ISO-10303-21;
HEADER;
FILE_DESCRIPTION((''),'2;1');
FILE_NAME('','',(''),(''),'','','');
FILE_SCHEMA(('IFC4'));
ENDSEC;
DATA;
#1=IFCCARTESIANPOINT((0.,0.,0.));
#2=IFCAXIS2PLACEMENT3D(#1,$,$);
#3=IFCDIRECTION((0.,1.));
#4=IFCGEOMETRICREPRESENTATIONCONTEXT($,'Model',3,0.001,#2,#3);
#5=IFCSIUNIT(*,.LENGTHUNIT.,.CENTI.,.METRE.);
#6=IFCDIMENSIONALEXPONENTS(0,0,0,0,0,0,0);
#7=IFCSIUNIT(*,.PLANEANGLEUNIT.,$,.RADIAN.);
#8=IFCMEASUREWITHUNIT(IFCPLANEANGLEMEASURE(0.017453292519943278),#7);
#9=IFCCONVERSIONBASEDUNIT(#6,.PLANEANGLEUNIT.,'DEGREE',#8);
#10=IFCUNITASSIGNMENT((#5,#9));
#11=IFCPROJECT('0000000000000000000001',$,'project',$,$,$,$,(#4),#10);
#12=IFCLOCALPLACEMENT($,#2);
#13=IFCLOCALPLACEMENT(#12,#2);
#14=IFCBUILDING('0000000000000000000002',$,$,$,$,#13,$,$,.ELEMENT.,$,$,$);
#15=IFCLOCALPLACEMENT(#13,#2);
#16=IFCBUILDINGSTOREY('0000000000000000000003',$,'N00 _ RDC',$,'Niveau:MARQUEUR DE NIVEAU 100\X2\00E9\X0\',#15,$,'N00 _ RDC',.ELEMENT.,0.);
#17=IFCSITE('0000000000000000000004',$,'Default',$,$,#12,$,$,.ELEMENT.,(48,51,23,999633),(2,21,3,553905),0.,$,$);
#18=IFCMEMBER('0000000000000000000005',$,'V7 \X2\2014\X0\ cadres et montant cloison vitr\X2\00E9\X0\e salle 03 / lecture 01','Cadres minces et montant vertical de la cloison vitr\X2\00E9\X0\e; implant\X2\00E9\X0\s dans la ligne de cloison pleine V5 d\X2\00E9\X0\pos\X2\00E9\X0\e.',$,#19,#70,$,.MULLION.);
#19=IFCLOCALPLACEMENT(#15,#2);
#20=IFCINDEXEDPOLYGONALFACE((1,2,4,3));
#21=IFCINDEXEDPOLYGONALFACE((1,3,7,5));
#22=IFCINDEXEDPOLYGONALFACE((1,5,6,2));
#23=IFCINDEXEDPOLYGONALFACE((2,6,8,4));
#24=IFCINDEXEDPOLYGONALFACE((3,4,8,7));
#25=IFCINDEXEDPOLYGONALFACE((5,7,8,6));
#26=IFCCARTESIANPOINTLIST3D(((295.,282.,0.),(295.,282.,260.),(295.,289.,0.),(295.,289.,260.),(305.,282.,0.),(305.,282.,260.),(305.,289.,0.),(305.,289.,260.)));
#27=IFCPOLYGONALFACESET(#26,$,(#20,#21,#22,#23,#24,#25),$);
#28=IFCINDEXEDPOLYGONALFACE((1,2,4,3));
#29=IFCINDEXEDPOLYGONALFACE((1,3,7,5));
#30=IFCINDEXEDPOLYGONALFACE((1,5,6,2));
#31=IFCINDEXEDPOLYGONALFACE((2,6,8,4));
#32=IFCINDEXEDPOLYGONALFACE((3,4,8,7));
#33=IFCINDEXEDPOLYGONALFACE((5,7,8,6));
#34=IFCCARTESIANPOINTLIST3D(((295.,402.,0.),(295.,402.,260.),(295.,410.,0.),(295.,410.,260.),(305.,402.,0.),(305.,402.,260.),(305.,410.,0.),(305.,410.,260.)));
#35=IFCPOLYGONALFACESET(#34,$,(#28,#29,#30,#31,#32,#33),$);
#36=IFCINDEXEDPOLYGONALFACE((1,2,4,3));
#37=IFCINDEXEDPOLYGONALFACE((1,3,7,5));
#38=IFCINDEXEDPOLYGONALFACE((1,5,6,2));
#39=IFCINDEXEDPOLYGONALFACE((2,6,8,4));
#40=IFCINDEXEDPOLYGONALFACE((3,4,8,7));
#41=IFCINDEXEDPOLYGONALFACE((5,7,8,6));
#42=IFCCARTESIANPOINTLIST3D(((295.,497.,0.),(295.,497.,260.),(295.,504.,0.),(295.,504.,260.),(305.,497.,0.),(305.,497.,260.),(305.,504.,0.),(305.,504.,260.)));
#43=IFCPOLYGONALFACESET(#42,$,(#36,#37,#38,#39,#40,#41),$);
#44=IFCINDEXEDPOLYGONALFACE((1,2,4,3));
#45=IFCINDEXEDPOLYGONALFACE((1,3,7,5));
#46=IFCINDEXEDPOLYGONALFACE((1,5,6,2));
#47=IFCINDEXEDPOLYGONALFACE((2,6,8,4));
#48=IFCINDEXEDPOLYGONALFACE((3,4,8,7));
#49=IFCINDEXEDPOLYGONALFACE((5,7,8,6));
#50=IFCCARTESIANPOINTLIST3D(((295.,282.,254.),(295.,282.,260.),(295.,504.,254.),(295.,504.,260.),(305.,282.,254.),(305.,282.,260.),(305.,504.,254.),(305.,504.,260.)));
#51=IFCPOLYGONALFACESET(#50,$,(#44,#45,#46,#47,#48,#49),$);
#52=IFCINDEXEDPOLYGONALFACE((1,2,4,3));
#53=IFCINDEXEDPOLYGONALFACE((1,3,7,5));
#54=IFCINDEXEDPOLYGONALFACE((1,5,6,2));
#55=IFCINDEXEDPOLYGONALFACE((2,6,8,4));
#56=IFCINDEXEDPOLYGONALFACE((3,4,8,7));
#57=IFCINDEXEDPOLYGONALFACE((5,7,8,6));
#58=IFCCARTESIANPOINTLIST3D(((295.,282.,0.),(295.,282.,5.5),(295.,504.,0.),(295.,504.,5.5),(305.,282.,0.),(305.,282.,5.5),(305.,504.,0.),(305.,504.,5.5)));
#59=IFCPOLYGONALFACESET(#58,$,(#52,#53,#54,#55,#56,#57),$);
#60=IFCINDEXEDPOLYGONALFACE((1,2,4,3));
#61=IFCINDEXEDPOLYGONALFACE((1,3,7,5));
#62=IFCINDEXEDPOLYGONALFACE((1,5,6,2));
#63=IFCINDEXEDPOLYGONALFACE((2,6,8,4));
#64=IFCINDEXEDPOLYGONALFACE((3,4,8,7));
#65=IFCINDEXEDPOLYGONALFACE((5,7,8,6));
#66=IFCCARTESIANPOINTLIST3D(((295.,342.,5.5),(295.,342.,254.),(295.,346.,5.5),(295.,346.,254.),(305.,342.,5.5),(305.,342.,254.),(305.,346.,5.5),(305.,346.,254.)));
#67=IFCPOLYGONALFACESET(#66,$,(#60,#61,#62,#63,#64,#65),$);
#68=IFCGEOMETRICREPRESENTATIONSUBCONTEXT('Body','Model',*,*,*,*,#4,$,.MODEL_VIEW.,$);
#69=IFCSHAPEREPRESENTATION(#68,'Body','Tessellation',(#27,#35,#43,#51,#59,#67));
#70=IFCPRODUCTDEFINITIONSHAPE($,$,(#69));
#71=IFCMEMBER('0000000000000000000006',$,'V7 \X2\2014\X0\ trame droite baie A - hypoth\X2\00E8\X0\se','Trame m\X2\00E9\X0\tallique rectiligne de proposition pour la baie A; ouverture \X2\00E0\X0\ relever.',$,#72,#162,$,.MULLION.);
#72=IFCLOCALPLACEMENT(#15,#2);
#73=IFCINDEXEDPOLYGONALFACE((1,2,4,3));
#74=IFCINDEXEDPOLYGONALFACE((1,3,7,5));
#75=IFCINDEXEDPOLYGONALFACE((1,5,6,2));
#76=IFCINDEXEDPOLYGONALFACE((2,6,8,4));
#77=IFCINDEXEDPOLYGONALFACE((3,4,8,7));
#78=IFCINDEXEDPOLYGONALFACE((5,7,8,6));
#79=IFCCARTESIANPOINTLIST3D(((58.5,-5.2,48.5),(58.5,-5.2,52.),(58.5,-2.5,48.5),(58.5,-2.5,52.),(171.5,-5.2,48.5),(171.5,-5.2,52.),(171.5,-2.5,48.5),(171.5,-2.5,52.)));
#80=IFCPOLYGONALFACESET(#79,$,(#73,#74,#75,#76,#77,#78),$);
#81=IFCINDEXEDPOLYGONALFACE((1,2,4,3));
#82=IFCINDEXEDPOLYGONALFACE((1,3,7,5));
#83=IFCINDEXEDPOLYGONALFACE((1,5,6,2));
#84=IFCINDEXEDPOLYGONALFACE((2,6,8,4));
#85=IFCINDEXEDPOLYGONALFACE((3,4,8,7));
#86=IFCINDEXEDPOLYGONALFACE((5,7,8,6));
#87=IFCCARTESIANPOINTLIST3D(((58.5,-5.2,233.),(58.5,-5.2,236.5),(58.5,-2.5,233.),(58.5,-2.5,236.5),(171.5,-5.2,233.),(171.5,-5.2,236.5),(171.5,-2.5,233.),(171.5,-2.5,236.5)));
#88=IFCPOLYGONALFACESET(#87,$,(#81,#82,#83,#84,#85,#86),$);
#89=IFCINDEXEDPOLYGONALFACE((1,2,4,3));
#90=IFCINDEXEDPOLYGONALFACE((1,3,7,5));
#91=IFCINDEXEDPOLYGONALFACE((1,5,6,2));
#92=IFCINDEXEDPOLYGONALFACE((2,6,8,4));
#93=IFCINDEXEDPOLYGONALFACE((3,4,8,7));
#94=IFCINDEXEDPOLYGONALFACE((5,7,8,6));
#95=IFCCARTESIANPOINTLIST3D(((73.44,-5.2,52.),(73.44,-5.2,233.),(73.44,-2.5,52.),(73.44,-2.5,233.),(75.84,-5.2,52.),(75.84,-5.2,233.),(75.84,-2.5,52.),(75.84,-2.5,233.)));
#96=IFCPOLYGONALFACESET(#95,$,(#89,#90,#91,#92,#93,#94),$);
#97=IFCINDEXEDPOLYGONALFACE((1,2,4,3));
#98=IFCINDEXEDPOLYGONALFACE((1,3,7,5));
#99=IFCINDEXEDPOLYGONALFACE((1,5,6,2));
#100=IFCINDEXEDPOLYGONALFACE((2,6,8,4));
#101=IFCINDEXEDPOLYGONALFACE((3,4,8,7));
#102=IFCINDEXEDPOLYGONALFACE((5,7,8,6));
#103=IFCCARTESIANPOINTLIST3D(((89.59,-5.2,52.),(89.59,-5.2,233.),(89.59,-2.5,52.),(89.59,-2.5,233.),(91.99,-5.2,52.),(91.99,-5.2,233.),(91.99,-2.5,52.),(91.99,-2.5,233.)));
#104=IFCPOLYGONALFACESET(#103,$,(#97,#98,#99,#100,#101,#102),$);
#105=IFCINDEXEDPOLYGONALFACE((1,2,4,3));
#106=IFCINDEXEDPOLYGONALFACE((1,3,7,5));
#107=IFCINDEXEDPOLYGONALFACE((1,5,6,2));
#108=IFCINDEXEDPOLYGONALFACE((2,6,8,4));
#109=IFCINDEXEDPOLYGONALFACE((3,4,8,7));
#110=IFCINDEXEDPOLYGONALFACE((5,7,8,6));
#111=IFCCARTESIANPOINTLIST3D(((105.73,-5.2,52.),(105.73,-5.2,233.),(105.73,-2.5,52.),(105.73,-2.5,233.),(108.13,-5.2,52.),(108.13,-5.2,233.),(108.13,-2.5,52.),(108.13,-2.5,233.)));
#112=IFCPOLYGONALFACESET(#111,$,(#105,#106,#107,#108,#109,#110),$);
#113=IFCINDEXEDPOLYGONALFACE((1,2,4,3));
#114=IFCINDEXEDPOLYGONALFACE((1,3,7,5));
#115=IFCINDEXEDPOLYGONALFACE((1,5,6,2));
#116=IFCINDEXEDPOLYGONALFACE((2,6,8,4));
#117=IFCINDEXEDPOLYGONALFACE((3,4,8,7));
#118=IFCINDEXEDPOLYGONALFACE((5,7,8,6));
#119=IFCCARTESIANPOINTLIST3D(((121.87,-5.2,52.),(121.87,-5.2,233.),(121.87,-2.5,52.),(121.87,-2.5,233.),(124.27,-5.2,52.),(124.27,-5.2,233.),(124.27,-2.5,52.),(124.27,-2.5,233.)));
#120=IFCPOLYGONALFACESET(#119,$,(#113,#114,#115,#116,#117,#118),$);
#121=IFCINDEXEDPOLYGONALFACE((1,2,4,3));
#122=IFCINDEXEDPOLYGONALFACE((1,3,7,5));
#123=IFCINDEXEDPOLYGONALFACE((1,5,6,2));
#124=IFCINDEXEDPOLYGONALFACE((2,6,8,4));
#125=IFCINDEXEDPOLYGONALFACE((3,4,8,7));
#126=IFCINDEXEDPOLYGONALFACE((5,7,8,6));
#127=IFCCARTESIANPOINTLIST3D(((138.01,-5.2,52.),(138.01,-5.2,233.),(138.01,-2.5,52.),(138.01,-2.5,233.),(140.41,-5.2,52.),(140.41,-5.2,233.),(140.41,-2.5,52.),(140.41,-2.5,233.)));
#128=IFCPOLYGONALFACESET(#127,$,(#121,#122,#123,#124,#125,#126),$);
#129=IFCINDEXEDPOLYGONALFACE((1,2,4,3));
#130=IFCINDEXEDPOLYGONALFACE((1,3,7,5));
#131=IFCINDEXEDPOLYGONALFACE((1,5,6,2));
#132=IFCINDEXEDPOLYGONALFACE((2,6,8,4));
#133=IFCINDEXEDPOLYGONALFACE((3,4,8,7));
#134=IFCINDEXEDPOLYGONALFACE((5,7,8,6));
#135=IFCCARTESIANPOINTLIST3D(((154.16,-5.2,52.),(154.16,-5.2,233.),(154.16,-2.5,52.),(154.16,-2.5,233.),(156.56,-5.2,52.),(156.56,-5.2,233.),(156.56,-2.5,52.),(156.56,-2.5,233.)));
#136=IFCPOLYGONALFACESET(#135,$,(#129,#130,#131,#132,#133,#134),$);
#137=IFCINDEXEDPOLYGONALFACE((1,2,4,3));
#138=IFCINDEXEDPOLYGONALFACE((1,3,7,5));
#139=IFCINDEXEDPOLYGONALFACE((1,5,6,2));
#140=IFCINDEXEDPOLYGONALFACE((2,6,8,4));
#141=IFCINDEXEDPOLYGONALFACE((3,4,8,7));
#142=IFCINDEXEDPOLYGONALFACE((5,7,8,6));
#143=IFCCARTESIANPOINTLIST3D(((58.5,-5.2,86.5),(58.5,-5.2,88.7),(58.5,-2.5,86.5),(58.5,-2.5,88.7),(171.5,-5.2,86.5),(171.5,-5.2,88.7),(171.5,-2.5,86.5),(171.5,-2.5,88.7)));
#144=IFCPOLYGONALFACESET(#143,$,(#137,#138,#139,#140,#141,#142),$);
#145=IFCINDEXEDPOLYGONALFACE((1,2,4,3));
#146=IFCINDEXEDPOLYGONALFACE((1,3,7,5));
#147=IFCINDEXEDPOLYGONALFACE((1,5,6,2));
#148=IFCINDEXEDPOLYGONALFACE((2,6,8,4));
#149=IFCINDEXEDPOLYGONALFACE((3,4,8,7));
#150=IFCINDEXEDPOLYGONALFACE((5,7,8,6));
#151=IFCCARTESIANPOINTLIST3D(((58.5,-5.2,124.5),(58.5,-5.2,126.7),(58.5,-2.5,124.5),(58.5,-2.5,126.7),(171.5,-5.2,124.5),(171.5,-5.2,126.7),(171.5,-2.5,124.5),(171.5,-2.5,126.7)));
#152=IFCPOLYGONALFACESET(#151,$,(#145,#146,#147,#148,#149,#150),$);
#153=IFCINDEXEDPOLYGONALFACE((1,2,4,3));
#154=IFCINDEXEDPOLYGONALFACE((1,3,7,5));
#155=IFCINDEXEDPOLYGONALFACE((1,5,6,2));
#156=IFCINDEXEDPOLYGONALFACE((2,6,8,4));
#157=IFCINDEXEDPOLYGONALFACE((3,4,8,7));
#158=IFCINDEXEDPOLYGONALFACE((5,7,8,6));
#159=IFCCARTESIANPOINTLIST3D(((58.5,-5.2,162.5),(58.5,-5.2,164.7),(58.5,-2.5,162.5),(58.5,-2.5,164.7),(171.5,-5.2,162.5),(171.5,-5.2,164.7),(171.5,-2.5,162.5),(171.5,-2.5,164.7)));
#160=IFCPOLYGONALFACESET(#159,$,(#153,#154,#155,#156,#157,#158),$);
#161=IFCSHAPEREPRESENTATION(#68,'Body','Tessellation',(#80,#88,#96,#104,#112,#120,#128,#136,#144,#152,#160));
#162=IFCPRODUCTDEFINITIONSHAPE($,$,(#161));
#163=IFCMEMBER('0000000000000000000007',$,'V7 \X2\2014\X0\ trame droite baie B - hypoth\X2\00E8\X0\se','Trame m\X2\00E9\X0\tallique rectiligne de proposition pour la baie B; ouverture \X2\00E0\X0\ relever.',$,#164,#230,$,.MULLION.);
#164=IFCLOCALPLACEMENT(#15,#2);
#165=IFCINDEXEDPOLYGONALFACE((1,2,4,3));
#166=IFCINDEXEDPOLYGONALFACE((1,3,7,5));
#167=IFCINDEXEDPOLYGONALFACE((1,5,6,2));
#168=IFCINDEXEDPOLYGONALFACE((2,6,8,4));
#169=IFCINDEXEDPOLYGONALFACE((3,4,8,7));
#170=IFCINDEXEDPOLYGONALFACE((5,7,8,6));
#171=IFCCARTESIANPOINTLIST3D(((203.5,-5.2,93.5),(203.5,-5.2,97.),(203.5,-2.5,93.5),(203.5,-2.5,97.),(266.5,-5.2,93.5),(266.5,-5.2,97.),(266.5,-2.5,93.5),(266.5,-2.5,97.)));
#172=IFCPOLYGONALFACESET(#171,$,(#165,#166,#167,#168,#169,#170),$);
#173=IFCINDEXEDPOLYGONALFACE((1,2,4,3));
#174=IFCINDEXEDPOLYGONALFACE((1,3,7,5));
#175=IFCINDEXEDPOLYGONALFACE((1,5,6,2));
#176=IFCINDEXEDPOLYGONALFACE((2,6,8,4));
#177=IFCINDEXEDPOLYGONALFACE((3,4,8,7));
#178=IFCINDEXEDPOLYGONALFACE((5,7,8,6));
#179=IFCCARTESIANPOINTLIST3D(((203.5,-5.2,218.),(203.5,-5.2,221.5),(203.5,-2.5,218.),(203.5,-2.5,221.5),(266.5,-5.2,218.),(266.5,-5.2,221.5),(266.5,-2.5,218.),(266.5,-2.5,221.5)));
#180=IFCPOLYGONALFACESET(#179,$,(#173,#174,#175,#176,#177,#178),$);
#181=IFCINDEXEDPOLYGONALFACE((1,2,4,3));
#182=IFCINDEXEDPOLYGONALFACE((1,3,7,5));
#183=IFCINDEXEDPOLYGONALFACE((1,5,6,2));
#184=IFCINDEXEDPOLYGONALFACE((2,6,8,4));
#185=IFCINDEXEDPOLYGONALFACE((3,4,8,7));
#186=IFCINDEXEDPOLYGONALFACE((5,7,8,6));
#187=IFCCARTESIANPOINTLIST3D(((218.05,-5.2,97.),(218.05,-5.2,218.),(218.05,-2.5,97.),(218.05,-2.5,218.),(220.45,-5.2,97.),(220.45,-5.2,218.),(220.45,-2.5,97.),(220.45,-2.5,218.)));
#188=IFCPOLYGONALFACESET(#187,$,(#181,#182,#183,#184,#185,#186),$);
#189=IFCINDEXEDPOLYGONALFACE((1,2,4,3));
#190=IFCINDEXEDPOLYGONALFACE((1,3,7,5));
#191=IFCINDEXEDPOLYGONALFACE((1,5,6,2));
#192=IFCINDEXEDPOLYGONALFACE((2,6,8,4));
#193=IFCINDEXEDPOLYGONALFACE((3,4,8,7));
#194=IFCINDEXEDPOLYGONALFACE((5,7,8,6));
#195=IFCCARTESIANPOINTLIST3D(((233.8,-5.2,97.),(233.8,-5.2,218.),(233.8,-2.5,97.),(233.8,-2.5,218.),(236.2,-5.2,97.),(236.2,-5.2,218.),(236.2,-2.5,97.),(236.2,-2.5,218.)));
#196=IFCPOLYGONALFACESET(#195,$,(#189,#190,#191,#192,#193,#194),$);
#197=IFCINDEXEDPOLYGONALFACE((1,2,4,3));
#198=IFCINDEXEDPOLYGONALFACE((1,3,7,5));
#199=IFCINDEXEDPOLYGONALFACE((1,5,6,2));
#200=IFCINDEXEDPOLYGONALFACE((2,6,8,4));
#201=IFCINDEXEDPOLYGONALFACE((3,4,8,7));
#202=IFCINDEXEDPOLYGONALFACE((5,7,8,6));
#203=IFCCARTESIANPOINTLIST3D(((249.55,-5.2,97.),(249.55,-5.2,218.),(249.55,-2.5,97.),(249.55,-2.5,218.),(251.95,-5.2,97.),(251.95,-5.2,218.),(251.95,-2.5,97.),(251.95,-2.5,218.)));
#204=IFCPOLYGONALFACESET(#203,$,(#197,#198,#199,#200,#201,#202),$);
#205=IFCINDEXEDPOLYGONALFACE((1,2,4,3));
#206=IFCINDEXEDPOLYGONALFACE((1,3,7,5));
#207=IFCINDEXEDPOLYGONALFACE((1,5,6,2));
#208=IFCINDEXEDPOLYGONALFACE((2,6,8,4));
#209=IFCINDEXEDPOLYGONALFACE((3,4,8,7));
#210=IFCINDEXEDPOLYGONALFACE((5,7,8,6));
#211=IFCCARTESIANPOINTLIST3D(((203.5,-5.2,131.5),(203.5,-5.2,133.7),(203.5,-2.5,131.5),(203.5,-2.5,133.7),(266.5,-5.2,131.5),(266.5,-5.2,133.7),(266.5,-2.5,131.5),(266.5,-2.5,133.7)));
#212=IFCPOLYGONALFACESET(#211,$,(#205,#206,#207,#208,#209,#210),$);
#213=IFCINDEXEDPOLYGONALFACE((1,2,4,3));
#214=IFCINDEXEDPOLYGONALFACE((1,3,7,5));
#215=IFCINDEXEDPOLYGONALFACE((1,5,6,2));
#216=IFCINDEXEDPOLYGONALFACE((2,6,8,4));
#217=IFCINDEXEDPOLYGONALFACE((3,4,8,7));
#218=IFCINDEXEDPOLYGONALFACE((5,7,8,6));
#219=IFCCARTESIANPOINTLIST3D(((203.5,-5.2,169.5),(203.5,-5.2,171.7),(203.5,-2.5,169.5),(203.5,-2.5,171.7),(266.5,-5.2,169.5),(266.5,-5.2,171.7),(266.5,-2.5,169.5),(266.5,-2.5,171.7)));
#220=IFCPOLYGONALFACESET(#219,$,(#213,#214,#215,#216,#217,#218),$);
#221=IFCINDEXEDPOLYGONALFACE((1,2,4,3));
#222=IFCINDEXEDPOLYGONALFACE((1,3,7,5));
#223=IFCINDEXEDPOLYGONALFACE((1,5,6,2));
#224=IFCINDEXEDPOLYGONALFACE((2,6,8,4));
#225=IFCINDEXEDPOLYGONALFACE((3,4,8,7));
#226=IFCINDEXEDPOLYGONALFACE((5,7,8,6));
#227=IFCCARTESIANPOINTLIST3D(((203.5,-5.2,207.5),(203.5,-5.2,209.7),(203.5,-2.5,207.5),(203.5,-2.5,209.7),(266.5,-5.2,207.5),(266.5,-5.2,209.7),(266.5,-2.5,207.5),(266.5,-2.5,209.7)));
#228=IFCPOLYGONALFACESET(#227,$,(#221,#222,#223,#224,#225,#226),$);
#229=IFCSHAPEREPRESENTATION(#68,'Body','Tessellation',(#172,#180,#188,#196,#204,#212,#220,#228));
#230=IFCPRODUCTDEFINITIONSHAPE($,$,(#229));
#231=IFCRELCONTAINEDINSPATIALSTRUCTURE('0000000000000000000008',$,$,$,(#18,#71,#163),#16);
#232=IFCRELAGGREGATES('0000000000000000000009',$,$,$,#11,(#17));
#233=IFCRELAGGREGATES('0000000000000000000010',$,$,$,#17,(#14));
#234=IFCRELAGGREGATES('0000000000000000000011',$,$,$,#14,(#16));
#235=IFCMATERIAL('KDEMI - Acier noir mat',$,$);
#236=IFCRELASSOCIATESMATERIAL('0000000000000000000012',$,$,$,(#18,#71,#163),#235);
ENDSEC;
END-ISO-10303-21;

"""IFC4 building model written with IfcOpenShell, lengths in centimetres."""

from ifc_helpers import new_model, entity, si_unit, converted_unit, direction, frame, frame_2d, origin, origin_with_axes, place, context, subcontext, project, spatial, rectangle, extrude, material, element, save


model = new_model("IFC4")

# Units and contexts
model_context = context("Model", 3, precision=0.001, world=origin(), true_north=direction((0.0, 1.0)))
body_context = subcontext(model_context, "Body", "Model", "MODEL_VIEW")
ifc_project = project(units=[si_unit("LENGTHUNIT", "METRE", prefix="CENTI"), converted_unit("PLANEANGLEUNIT", "DEGREE", entity("IfcPlaneAngleMeasure", 0.017453292519943278), si_unit("PLANEANGLEUNIT", "RADIAN"), dimensions=[0, 0, 0, 0, 0, 0, 0])], contexts=[model_context])

# Site, building, storey
site_placement = place(None, origin())
site = spatial("IfcSite", under=ifc_project, at=site_placement, Name="Default", CompositionType="ELEMENT", RefLatitude=(48, 51, 23, 999633), RefLongitude=(2, 21, 3, 553905), RefElevation=0.0)
building_placement = place(site_placement, origin())
building = spatial("IfcBuilding", under=site, at=building_placement, CompositionType="ELEMENT")
storey_placement = place(building_placement, origin())
storey = spatial("IfcBuildingStorey", under=building, at=storey_placement, Name="N00 _ RDC", ObjectType="Niveau:MARQUEUR DE NIVEAU 100é", LongName="N00 _ RDC", CompositionType="ELEMENT", Elevation=0.0)

# Members
ifc_material_1 = material(Name="KDEMI - Acier noir mat")
member_1_placement = place(storey_placement, origin_with_axes())
element("IfcMember", 1, at=member_1_placement, inside=storey, material=ifc_material_1, Name="V7 — cadres et montant cloison vitrée salle 03 / lecture 01", Description="Cadres minces et montant vertical de la cloison vitrée; implantés dans la ligne de cloison pleine V5 déposée.", PredefinedType="MULLION", context=body_context, shape_type="SweptSolid", body=[
    extrude(rectangle(XDim=10.0, YDim=7.0, at=frame_2d((300.0, 285.5))), origin(), (0.0, 0.0, 1.0), 260.0),
    extrude(rectangle(XDim=10.0, YDim=8.0, at=frame_2d((300.0, 406.0))), origin(), (0.0, 0.0, 1.0), 260.0),
    extrude(rectangle(XDim=10.0, YDim=7.0, at=frame_2d((300.0, 500.5))), origin(), (0.0, 0.0, 1.0), 260.0),
    extrude(rectangle(XDim=10.0, YDim=222.0, at=frame_2d((300.0, 393.0))), frame((0.0, 0.0, 254.0)), (0.0, 0.0, 1.0), 6.0),
    extrude(rectangle(XDim=10.0, YDim=222.0, at=frame_2d((300.0, 393.0))), origin(), (0.0, 0.0, 1.0), 5.5),
    extrude(rectangle(XDim=10.0, YDim=4.0, at=frame_2d((300.0, 344.0))), frame((0.0, 0.0, 5.5)), (0.0, 0.0, 1.0), 248.5),
])
member_2_placement = place(storey_placement, origin_with_axes())
element("IfcMember", 2, at=member_2_placement, inside=storey, material=ifc_material_1, Name="V7 — trame droite baie A - hypothèse", Description="Trame métallique rectiligne de proposition pour la baie A; ouverture à relever.", PredefinedType="MULLION", context=body_context, shape_type="SweptSolid", body=[
    extrude(rectangle(XDim=113.0, YDim=2.7, at=frame_2d((115.0, -3.85))), frame((0.0, 0.0, 48.5)), (0.0, 0.0, 1.0), 3.5),
    extrude(rectangle(XDim=113.0, YDim=2.7, at=frame_2d((115.0, -3.85))), frame((0.0, 0.0, 233.0)), (0.0, 0.0, 1.0), 3.5),
    extrude(rectangle(XDim=2.4, YDim=2.7, at=frame_2d((74.64, -3.85))), frame((0.0, 0.0, 52.0)), (0.0, 0.0, 1.0), 181.0),
    extrude(rectangle(XDim=2.4, YDim=2.7, at=frame_2d((90.79, -3.85))), frame((0.0, 0.0, 52.0)), (0.0, 0.0, 1.0), 181.0),
    extrude(rectangle(XDim=2.4, YDim=2.7, at=frame_2d((106.93, -3.85))), frame((0.0, 0.0, 52.0)), (0.0, 0.0, 1.0), 181.0),
    extrude(rectangle(XDim=2.4, YDim=2.7, at=frame_2d((123.07, -3.85))), frame((0.0, 0.0, 52.0)), (0.0, 0.0, 1.0), 181.0),
    extrude(rectangle(XDim=2.4, YDim=2.7, at=frame_2d((139.21, -3.85))), frame((0.0, 0.0, 52.0)), (0.0, 0.0, 1.0), 181.0),
    extrude(rectangle(XDim=2.4, YDim=2.7, at=frame_2d((155.36, -3.85))), frame((0.0, 0.0, 52.0)), (0.0, 0.0, 1.0), 181.0),
    extrude(rectangle(XDim=113.0, YDim=2.7, at=frame_2d((115.0, -3.85))), frame((0.0, 0.0, 86.5)), (0.0, 0.0, 1.0), 2.2),
    extrude(rectangle(XDim=113.0, YDim=2.7, at=frame_2d((115.0, -3.85))), frame((0.0, 0.0, 124.5)), (0.0, 0.0, 1.0), 2.2),
    extrude(rectangle(XDim=113.0, YDim=2.7, at=frame_2d((115.0, -3.85))), frame((0.0, 0.0, 162.5)), (0.0, 0.0, 1.0), 2.2),
])
member_3_placement = place(storey_placement, origin_with_axes())
element("IfcMember", 3, at=member_3_placement, inside=storey, material=ifc_material_1, Name="V7 — trame droite baie B - hypothèse", Description="Trame métallique rectiligne de proposition pour la baie B; ouverture à relever.", PredefinedType="MULLION", context=body_context, shape_type="SweptSolid", body=[
    extrude(rectangle(XDim=63.0, YDim=2.7, at=frame_2d((235.0, -3.85))), frame((0.0, 0.0, 93.5)), (0.0, 0.0, 1.0), 3.5),
    extrude(rectangle(XDim=63.0, YDim=2.7, at=frame_2d((235.0, -3.85))), frame((0.0, 0.0, 218.0)), (0.0, 0.0, 1.0), 3.5),
    extrude(rectangle(XDim=2.4, YDim=2.7, at=frame_2d((219.25, -3.85))), frame((0.0, 0.0, 97.0)), (0.0, 0.0, 1.0), 121.0),
    extrude(rectangle(XDim=2.4, YDim=2.7, at=frame_2d((235.0, -3.85))), frame((0.0, 0.0, 97.0)), (0.0, 0.0, 1.0), 121.0),
    extrude(rectangle(XDim=2.4, YDim=2.7, at=frame_2d((250.75, -3.85))), frame((0.0, 0.0, 97.0)), (0.0, 0.0, 1.0), 121.0),
    extrude(rectangle(XDim=63.0, YDim=2.7, at=frame_2d((235.0, -3.85))), frame((0.0, 0.0, 131.5)), (0.0, 0.0, 1.0), 2.2),
    extrude(rectangle(XDim=63.0, YDim=2.7, at=frame_2d((235.0, -3.85))), frame((0.0, 0.0, 169.5)), (0.0, 0.0, 1.0), 2.2),
    extrude(rectangle(XDim=63.0, YDim=2.7, at=frame_2d((235.0, -3.85))), frame((0.0, 0.0, 207.5)), (0.0, 0.0, 1.0), 2.2),
])

save(model, "model.ifc")
